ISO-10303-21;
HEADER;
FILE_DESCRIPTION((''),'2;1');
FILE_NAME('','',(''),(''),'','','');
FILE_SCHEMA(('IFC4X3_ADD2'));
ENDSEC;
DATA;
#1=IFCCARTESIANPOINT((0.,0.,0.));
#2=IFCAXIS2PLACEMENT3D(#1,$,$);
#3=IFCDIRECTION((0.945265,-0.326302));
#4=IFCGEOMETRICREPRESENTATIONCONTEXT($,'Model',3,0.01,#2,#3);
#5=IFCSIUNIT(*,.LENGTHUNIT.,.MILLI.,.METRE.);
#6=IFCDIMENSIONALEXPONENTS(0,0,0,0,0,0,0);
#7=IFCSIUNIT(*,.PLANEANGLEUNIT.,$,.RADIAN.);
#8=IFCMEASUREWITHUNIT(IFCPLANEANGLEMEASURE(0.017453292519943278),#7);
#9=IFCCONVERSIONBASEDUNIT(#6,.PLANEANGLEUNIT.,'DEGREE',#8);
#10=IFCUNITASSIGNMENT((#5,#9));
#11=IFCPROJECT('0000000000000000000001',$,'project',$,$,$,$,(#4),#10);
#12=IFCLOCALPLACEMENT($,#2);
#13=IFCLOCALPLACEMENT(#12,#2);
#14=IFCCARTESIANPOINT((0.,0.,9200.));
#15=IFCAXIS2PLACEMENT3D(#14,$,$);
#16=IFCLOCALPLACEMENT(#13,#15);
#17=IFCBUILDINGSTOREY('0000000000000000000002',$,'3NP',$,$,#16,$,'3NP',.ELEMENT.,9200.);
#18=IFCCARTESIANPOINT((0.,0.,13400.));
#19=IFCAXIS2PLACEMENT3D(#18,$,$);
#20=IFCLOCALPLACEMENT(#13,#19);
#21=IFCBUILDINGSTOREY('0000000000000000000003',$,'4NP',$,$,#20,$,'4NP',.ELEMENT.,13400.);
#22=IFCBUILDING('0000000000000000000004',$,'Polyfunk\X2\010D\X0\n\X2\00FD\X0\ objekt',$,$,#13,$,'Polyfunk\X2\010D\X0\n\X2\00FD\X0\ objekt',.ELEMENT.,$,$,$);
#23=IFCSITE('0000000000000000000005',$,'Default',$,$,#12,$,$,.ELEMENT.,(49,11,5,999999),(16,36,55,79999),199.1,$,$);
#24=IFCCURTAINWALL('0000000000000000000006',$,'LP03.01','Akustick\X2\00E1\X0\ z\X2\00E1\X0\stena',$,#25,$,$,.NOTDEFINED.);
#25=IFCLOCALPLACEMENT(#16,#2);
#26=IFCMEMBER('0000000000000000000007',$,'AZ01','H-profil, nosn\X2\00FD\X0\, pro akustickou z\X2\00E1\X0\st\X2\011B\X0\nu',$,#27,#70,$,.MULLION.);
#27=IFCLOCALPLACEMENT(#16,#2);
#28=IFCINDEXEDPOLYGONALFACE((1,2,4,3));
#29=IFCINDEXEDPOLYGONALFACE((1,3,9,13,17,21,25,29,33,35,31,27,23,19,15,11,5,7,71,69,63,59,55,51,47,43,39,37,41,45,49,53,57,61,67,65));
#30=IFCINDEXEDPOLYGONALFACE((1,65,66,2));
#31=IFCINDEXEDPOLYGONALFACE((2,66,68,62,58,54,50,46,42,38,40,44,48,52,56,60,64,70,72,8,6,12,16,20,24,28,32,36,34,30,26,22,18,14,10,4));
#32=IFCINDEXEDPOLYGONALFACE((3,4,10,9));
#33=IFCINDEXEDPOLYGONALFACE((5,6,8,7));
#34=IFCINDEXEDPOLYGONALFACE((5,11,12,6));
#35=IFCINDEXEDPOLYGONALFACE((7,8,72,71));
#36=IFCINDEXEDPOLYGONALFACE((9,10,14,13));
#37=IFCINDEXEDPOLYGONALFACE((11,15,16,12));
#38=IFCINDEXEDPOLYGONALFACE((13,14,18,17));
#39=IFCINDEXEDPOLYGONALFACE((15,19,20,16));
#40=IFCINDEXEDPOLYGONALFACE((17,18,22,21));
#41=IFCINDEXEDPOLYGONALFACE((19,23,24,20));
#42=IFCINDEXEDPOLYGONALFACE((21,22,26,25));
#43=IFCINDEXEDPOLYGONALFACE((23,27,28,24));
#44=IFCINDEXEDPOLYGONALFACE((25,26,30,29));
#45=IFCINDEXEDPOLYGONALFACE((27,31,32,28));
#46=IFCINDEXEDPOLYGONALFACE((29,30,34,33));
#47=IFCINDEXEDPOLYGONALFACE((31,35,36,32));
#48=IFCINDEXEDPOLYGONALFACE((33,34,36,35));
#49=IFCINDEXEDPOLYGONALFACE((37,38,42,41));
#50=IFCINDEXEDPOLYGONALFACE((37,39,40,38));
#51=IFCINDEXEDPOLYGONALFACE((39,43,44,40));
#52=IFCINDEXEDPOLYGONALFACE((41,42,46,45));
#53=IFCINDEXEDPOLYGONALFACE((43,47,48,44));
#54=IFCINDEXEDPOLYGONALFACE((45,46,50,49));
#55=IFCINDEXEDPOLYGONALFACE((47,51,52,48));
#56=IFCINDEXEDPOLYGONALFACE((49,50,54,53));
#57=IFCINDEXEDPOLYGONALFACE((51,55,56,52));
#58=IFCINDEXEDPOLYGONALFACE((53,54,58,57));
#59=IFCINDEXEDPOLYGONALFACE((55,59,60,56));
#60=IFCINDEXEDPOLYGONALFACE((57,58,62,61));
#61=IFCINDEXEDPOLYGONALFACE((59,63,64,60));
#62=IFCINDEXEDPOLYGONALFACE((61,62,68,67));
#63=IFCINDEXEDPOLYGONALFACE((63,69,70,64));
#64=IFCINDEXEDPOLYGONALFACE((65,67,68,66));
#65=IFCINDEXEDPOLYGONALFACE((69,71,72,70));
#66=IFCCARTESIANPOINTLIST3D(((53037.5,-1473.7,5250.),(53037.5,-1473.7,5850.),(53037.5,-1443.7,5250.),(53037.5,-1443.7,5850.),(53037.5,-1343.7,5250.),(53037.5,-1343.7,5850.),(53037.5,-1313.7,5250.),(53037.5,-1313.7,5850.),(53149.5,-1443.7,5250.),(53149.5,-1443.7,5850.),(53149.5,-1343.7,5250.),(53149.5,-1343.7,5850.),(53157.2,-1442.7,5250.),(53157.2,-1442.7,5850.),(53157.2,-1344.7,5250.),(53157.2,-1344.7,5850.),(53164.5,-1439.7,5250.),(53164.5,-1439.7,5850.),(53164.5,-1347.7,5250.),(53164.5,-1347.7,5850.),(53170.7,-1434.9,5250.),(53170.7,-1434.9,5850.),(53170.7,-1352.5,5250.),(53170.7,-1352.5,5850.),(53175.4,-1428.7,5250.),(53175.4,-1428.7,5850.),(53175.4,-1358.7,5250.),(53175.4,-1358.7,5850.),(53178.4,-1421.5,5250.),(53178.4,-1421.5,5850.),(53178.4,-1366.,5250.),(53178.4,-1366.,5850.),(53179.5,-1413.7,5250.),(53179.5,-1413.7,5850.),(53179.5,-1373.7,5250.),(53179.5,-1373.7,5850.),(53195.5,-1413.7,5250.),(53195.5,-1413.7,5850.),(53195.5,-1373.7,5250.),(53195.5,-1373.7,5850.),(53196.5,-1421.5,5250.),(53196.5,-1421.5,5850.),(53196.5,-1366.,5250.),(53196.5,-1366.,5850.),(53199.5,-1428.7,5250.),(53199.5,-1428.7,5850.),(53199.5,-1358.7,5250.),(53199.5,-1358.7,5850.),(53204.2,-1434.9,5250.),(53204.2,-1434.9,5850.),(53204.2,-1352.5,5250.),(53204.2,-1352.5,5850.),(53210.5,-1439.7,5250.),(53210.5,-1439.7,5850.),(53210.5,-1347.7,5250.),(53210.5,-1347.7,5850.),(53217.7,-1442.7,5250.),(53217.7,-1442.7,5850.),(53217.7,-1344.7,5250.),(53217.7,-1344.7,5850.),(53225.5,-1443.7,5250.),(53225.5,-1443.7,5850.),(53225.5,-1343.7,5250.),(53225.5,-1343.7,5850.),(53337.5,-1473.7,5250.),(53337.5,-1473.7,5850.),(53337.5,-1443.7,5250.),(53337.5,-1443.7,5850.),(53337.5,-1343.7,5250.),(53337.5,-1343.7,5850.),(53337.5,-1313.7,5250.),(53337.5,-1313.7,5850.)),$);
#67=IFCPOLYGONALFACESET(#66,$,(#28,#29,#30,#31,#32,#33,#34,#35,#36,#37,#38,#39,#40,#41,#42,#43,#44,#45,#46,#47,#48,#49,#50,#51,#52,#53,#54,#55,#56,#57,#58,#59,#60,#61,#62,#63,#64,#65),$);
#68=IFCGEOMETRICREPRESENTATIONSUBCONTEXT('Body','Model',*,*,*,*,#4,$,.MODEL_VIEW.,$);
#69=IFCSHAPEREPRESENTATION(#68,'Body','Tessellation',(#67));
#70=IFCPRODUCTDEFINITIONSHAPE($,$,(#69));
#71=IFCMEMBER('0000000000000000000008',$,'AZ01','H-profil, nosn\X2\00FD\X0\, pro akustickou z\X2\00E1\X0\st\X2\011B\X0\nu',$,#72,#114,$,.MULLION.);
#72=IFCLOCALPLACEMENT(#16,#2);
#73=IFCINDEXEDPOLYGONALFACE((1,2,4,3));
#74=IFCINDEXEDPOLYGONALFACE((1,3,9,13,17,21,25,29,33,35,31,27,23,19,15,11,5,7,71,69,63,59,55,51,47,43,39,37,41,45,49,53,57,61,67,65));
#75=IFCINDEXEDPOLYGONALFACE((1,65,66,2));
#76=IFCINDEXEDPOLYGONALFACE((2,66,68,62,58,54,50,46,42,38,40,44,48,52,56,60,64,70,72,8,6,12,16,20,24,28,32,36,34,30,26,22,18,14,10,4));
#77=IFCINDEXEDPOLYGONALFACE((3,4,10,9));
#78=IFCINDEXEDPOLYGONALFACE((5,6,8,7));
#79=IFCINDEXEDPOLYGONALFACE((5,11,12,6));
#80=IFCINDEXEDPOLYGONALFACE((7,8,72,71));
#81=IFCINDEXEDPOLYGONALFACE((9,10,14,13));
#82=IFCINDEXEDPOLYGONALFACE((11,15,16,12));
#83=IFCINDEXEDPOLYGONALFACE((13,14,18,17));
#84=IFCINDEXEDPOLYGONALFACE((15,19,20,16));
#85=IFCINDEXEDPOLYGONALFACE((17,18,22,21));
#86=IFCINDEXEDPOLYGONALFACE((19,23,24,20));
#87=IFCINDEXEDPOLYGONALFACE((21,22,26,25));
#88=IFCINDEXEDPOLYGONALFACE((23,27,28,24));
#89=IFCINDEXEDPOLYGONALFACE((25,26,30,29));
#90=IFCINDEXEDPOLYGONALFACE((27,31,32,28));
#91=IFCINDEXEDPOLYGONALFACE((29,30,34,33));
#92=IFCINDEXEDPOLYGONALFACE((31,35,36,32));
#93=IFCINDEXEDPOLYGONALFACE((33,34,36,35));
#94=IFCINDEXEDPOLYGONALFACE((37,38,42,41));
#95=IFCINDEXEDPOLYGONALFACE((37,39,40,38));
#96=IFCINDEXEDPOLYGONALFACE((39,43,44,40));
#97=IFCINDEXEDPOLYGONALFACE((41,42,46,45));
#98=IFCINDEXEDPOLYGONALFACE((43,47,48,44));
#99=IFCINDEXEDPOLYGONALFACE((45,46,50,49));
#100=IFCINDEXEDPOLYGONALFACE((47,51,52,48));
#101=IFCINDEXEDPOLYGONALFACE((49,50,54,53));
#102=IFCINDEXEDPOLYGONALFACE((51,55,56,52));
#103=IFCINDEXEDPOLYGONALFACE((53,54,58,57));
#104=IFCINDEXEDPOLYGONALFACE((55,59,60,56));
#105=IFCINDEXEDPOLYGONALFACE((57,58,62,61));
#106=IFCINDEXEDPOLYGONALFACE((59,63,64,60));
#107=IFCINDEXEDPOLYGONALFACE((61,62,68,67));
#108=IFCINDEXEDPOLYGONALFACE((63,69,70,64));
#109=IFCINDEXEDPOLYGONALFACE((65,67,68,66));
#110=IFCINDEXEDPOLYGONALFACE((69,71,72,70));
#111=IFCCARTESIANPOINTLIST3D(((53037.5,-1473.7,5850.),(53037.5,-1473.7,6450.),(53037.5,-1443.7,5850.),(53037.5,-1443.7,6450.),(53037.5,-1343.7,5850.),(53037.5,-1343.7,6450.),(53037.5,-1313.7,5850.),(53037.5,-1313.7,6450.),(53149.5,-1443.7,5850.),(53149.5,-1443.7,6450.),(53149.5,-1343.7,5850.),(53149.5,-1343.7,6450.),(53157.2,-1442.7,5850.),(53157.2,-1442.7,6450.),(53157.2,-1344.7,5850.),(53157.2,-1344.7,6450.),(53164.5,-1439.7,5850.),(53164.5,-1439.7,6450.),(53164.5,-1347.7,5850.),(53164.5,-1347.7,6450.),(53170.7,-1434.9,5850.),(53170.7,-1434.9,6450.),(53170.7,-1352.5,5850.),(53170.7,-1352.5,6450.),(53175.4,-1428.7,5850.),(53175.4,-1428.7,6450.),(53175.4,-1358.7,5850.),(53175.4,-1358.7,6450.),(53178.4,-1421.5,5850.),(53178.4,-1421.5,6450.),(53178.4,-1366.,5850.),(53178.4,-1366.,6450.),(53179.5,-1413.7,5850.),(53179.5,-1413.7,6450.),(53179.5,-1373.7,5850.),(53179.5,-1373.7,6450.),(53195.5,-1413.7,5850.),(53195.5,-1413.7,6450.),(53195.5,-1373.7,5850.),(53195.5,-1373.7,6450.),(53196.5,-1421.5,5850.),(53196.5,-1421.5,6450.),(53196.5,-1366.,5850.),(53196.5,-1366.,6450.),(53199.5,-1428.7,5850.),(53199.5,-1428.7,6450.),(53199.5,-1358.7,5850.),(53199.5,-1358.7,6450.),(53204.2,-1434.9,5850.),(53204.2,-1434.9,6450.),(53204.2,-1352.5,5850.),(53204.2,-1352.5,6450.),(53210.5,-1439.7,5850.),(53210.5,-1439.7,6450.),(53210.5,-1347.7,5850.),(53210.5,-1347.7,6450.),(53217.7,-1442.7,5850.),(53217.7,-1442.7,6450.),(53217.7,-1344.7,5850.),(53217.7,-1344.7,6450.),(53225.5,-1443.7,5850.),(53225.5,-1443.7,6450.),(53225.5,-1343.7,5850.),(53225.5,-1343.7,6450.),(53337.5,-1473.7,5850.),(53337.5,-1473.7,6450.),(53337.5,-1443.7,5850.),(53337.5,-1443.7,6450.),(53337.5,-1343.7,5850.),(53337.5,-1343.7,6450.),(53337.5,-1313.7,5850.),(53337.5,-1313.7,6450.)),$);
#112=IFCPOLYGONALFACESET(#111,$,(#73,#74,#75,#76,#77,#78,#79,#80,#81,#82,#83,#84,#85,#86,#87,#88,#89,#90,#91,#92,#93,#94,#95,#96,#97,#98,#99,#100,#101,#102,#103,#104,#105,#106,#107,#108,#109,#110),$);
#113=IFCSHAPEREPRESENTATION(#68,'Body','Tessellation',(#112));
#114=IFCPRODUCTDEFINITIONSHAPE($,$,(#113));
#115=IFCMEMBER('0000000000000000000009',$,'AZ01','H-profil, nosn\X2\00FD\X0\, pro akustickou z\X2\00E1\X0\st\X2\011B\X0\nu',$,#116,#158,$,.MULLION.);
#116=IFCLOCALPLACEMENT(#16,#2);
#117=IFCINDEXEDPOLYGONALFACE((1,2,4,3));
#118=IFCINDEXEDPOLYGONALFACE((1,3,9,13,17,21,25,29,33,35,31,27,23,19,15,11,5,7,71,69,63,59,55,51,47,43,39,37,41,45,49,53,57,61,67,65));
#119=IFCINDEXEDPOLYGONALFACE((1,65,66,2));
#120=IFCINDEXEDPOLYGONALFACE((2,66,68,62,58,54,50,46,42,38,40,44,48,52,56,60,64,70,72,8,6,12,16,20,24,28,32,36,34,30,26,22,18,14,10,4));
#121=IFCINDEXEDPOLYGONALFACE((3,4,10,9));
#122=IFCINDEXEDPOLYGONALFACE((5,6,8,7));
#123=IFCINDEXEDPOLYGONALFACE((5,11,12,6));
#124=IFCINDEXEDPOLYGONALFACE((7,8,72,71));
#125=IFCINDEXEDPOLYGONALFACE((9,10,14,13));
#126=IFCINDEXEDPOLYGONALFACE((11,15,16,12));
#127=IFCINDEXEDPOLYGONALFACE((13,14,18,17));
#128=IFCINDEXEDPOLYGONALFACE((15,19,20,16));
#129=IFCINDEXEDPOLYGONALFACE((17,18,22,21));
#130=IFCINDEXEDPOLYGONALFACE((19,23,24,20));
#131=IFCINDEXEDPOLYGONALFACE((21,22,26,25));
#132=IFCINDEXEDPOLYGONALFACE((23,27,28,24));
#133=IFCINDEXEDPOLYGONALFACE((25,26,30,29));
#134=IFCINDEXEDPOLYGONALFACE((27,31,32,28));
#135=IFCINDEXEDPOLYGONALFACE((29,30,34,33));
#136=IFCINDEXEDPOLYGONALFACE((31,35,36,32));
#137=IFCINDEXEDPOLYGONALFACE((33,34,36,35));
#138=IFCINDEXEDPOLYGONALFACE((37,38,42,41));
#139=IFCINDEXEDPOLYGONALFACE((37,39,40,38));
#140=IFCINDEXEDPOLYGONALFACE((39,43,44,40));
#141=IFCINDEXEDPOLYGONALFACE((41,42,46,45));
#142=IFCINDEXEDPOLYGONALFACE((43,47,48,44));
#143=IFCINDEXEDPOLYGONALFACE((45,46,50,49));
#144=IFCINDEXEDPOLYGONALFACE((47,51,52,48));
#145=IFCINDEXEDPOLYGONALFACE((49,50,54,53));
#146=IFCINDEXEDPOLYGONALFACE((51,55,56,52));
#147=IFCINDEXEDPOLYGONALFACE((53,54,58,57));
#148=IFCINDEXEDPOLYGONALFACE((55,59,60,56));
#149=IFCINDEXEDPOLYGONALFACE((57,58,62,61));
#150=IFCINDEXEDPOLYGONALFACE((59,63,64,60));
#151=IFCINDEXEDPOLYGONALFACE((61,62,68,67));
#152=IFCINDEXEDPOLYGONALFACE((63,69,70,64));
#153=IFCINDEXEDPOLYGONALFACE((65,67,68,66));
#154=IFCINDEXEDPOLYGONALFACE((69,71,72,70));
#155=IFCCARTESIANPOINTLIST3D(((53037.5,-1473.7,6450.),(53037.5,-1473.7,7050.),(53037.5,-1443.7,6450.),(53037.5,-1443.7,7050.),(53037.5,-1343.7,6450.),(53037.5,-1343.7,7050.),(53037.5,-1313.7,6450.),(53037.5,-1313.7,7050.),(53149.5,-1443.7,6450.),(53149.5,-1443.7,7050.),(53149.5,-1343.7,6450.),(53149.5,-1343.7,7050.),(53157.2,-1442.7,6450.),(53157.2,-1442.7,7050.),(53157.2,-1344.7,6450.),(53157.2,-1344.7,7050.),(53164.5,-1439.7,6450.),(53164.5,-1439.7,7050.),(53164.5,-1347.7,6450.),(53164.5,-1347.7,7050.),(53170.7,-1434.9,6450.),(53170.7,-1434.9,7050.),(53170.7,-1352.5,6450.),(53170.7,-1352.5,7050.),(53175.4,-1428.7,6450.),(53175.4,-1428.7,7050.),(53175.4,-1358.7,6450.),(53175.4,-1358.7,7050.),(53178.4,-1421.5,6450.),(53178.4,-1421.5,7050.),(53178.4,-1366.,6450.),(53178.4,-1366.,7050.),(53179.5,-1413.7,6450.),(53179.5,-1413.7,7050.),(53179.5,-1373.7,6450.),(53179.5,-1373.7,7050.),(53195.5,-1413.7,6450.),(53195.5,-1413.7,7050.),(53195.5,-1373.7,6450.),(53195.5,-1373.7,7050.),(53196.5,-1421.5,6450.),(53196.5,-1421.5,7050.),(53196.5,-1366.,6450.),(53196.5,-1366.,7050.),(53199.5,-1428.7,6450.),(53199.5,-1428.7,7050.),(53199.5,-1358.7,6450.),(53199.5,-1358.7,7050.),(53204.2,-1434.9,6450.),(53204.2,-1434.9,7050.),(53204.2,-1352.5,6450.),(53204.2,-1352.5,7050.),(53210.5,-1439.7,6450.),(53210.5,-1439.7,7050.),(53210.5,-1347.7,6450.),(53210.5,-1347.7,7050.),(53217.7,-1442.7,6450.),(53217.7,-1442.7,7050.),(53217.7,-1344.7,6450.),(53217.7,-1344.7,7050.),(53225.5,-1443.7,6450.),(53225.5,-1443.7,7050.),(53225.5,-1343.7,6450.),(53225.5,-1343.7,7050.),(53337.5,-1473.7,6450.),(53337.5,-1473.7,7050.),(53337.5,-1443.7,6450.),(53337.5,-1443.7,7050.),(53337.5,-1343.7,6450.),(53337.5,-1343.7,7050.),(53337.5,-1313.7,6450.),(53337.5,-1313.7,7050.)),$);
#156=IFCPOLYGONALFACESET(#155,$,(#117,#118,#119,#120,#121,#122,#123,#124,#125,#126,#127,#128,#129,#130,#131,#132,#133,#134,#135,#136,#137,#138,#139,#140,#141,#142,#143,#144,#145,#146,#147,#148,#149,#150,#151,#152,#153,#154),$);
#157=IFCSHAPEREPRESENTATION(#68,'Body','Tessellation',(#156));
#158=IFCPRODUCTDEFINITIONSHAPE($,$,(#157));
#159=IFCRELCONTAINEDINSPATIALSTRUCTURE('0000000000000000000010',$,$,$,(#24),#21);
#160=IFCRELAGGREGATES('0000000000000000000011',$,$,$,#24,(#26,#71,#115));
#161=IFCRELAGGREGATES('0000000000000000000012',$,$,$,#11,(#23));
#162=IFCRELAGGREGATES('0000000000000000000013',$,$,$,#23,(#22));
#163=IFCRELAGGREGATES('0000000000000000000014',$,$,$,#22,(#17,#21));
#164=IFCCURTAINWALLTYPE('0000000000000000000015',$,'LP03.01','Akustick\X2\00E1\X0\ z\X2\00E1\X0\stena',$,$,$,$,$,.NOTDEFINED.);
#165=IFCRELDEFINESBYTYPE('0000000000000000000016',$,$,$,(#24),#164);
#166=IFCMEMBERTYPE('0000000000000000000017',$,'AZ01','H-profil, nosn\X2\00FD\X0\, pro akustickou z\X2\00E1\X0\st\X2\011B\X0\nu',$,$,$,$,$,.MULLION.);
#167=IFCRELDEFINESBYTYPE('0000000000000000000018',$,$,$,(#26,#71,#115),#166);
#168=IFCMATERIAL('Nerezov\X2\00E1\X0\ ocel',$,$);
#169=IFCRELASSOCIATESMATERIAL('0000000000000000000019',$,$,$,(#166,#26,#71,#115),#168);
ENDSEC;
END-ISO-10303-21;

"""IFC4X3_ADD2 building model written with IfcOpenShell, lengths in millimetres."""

from ifc_helpers import new_model, entity, si_unit, converted_unit, direction, frame, frame_2d, origin, place, context, subcontext, project, spatial, polyline, circle_curve, parameter, trimmed, segment, composite_curve, outline, extrude, source, transform, mapped, material, material_profile, profile_set, profile_usage, type_object, element, aggregate, save


model = new_model("IFC4X3_ADD2")

# Units and contexts
model_context = context("Model", 3, precision=0.01, world=origin(), true_north=direction((0.945265, -0.326302)))
body_context = subcontext(model_context, "Body", "Model", "MODEL_VIEW")
ifc_project = project(units=[si_unit("LENGTHUNIT", "METRE", prefix="MILLI"), converted_unit("PLANEANGLEUNIT", "DEGREE", entity("IfcPlaneAngleMeasure", 0.017453292519943278), si_unit("PLANEANGLEUNIT", "RADIAN"), dimensions=[0, 0, 0, 0, 0, 0, 0])], contexts=[model_context])

# Site, building, storey
site_placement = place(None, origin())
site = spatial("IfcSite", under=ifc_project, at=site_placement, Name="Default", CompositionType="ELEMENT", RefLatitude=(49, 11, 5, 999999), RefLongitude=(16, 36, 55, 79999), RefElevation=199.1)
building_placement = place(site_placement, origin())
building = spatial("IfcBuilding", under=site, at=building_placement, Name="Polyfunkčný objekt", LongName="Polyfunkčný objekt", CompositionType="ELEMENT")
storey_1_placement = place(building_placement, frame((0.0, 0.0, 9200.0)))
storey_1 = spatial("IfcBuildingStorey", under=building, at=storey_1_placement, Name="3NP", LongName="3NP", CompositionType="ELEMENT", Elevation=9200.0)

# Shared definitions
storey_2_placement = place(building_placement, frame((0.0, 0.0, 13400.0)))
storey_2 = spatial("IfcBuildingStorey", under=building, at=storey_2_placement, Name="4NP", LongName="4NP", CompositionType="ELEMENT", Elevation=13400.0)

# Curtain wall, members
curtain_wall_type_1 = type_object("IfcCurtainWallType", Name="LP03.01", Description="Akustická zástena", PredefinedType="NOTDEFINED")
curtain_wall_1_placement = place(storey_2_placement, frame((0.0, 0.0, -13400.0)))
curtain_wall_1 = element("IfcCurtainWall", 1, at=curtain_wall_1_placement, inside=storey_2, type_object=curtain_wall_type_1, Name="LP03.01", Description="Akustická zástena", PredefinedType="NOTDEFINED")
ifc_material_1 = material(Name="Nerezová ocel")
ifc_material_profile_1 = material_profile(ifc_material_1, outline(composite_curve([segment(polyline([(50.0, -150.0), (80.0, -150.0)]), True, "CONTINUOUS"), segment(polyline([(80.0, -150.0), (80.0, 150.0)]), True, "CONTINUOUS"), segment(polyline([(80.0, 150.0), (50.0, 150.0)]), True, "CONTINUOUS"), segment(polyline([(50.0, 150.0), (50.0, 38.0)]), True, "CONTINUOUS"), segment(trimmed(circle_curve(frame_2d((20.0, 38.0), x_axis=(0.0, 1.0)), 30.0), [parameter(180.0)], [parameter(270.0)], True, "PARAMETER"), False, "CONTINUOUS"), segment(polyline([(20.0, 8.0), (-20.0, 8.0)]), True, "CONTINUOUS"), segment(trimmed(circle_curve(frame_2d((-20.0, 38.0), x_axis=(0.0, 1.0)), 30.0), [parameter(90.0)], [parameter(180.0)], True, "PARAMETER"), False, "CONTINUOUS"), segment(polyline([(-50.0, 38.0), (-50.0, 150.0)]), True, "CONTINUOUS"), segment(polyline([(-50.0, 150.0), (-80.0, 150.0)]), True, "CONTINUOUS"), segment(polyline([(-80.0, 150.0), (-80.0, -150.0)]), True, "CONTINUOUS"), segment(polyline([(-80.0, -150.0), (-50.0, -150.0)]), True, "CONTINUOUS"), segment(polyline([(-50.0, -150.0), (-50.0, -38.0)]), True, "CONTINUOUS"), segment(trimmed(circle_curve(frame_2d((-20.0, -38.0), x_axis=(0.0, 1.0)), 30.0), [parameter(0.0)], [parameter(90.0)], True, "PARAMETER"), False, "CONTINUOUS"), segment(polyline([(-20.0, -8.0), (20.0, -8.0)]), True, "CONTINUOUS"), segment(trimmed(circle_curve(frame_2d((20.0, -38.0), x_axis=(0.0, 1.0)), 30.0), [parameter(270.0)], [parameter(0.0)], True, "PARAMETER"), False, "CONTINUOUS"), segment(polyline([(50.0, -38.0), (50.0, -150.0)]), True, "CONTINUOUS")], self_intersect=False)), Name="Profil zástena")
ifc_profile_set_1 = profile_set([ifc_material_profile_1], Name="Profil zástena")
ifc_profile_usage_1 = profile_usage(ifc_profile_set_1)
member_type_1 = type_object("IfcMemberType", Name="AZ01", Description="H-profil, nosný, pro akustickou zástěnu", PredefinedType="MULLION", material=ifc_profile_set_1)
shared_shape_1 = source(origin(), body_context, "Body", "SweptSolid", [
    extrude(outline(composite_curve([segment(polyline([(50.0, -150.0), (80.0, -150.0)]), True, "CONTINUOUS"), segment(polyline([(80.0, -150.0), (80.0, 150.0)]), True, "CONTINUOUS"), segment(polyline([(80.0, 150.0), (50.0, 150.0)]), True, "CONTINUOUS"), segment(polyline([(50.0, 150.0), (50.0, 38.0)]), True, "CONTINUOUS"), segment(trimmed(circle_curve(frame_2d((20.0, 38.0), x_axis=(0.0, 1.0)), 30.0), [parameter(180.0)], [parameter(270.0)], True, "PARAMETER"), False, "CONTINUOUS"), segment(polyline([(20.0, 8.0), (-20.0, 8.0)]), True, "CONTINUOUS"), segment(trimmed(circle_curve(frame_2d((-20.0, 38.0), x_axis=(0.0, 1.0)), 30.0), [parameter(90.0)], [parameter(180.0)], True, "PARAMETER"), False, "CONTINUOUS"), segment(polyline([(-50.0, 38.0), (-50.0, 150.0)]), True, "CONTINUOUS"), segment(polyline([(-50.0, 150.0), (-80.0, 150.0)]), True, "CONTINUOUS"), segment(polyline([(-80.0, 150.0), (-80.0, -150.0)]), True, "CONTINUOUS"), segment(polyline([(-80.0, -150.0), (-50.0, -150.0)]), True, "CONTINUOUS"), segment(polyline([(-50.0, -150.0), (-50.0, -38.0)]), True, "CONTINUOUS"), segment(trimmed(circle_curve(frame_2d((-20.0, -38.0), x_axis=(0.0, 1.0)), 30.0), [parameter(0.0)], [parameter(90.0)], True, "PARAMETER"), False, "CONTINUOUS"), segment(polyline([(-20.0, -8.0), (20.0, -8.0)]), True, "CONTINUOUS"), segment(trimmed(circle_curve(frame_2d((20.0, -38.0), x_axis=(0.0, 1.0)), 30.0), [parameter(270.0)], [parameter(0.0)], True, "PARAMETER"), False, "CONTINUOUS"), segment(polyline([(50.0, -38.0), (50.0, -150.0)]), True, "CONTINUOUS")], self_intersect=False)), frame((0.0, 0.0, -600.0), z_axis=(0.0, 0.0, 1.0), x_axis=(0.0, -1.0, 0.0)), (0.0, 0.0, 1.0), 600.0),
])
member_1_placement = place(curtain_wall_1_placement, frame((53187.5, -1393.7, 14450.0), z_axis=(0.0, 0.0, -1.0), x_axis=(1.0, 0.0, 0.0)))
member_1 = element("IfcMember", 2, at=member_1_placement, type_object=member_type_1, material=ifc_profile_usage_1, Name="AZ01", Description="H-profil, nosný, pro akustickou zástěnu", PredefinedType="MULLION", context=body_context, shape_type="MappedRepresentation", body=[
    mapped(shared_shape_1, transform((0.0, 0.0, 0.0), scale=1.0)),
])
member_2_placement = place(curtain_wall_1_placement, frame((53187.5, -1393.7, 15050.0), z_axis=(0.0, 0.0, -1.0), x_axis=(1.0, 0.0, 0.0)))
member_2 = element("IfcMember", 3, at=member_2_placement, type_object=member_type_1, material=ifc_profile_usage_1, Name="AZ01", Description="H-profil, nosný, pro akustickou zástěnu", PredefinedType="MULLION", context=body_context, shape_type="MappedRepresentation", body=[
    mapped(shared_shape_1, transform((0.0, 0.0, 0.0), scale=1.0)),
])
member_3_placement = place(curtain_wall_1_placement, frame((53187.5, -1393.7, 15650.0), z_axis=(0.0, 0.0, -1.0), x_axis=(1.0, 0.0, 0.0)))
member_3 = element("IfcMember", 4, at=member_3_placement, type_object=member_type_1, material=ifc_profile_usage_1, Name="AZ01", Description="H-profil, nosný, pro akustickou zástěnu", PredefinedType="MULLION", context=body_context, shape_type="MappedRepresentation", body=[
    mapped(shared_shape_1, transform((0.0, 0.0, 0.0), scale=1.0)),
])

aggregate(curtain_wall_1, [member_1, member_2, member_3])

save(model, "model.ifc")
